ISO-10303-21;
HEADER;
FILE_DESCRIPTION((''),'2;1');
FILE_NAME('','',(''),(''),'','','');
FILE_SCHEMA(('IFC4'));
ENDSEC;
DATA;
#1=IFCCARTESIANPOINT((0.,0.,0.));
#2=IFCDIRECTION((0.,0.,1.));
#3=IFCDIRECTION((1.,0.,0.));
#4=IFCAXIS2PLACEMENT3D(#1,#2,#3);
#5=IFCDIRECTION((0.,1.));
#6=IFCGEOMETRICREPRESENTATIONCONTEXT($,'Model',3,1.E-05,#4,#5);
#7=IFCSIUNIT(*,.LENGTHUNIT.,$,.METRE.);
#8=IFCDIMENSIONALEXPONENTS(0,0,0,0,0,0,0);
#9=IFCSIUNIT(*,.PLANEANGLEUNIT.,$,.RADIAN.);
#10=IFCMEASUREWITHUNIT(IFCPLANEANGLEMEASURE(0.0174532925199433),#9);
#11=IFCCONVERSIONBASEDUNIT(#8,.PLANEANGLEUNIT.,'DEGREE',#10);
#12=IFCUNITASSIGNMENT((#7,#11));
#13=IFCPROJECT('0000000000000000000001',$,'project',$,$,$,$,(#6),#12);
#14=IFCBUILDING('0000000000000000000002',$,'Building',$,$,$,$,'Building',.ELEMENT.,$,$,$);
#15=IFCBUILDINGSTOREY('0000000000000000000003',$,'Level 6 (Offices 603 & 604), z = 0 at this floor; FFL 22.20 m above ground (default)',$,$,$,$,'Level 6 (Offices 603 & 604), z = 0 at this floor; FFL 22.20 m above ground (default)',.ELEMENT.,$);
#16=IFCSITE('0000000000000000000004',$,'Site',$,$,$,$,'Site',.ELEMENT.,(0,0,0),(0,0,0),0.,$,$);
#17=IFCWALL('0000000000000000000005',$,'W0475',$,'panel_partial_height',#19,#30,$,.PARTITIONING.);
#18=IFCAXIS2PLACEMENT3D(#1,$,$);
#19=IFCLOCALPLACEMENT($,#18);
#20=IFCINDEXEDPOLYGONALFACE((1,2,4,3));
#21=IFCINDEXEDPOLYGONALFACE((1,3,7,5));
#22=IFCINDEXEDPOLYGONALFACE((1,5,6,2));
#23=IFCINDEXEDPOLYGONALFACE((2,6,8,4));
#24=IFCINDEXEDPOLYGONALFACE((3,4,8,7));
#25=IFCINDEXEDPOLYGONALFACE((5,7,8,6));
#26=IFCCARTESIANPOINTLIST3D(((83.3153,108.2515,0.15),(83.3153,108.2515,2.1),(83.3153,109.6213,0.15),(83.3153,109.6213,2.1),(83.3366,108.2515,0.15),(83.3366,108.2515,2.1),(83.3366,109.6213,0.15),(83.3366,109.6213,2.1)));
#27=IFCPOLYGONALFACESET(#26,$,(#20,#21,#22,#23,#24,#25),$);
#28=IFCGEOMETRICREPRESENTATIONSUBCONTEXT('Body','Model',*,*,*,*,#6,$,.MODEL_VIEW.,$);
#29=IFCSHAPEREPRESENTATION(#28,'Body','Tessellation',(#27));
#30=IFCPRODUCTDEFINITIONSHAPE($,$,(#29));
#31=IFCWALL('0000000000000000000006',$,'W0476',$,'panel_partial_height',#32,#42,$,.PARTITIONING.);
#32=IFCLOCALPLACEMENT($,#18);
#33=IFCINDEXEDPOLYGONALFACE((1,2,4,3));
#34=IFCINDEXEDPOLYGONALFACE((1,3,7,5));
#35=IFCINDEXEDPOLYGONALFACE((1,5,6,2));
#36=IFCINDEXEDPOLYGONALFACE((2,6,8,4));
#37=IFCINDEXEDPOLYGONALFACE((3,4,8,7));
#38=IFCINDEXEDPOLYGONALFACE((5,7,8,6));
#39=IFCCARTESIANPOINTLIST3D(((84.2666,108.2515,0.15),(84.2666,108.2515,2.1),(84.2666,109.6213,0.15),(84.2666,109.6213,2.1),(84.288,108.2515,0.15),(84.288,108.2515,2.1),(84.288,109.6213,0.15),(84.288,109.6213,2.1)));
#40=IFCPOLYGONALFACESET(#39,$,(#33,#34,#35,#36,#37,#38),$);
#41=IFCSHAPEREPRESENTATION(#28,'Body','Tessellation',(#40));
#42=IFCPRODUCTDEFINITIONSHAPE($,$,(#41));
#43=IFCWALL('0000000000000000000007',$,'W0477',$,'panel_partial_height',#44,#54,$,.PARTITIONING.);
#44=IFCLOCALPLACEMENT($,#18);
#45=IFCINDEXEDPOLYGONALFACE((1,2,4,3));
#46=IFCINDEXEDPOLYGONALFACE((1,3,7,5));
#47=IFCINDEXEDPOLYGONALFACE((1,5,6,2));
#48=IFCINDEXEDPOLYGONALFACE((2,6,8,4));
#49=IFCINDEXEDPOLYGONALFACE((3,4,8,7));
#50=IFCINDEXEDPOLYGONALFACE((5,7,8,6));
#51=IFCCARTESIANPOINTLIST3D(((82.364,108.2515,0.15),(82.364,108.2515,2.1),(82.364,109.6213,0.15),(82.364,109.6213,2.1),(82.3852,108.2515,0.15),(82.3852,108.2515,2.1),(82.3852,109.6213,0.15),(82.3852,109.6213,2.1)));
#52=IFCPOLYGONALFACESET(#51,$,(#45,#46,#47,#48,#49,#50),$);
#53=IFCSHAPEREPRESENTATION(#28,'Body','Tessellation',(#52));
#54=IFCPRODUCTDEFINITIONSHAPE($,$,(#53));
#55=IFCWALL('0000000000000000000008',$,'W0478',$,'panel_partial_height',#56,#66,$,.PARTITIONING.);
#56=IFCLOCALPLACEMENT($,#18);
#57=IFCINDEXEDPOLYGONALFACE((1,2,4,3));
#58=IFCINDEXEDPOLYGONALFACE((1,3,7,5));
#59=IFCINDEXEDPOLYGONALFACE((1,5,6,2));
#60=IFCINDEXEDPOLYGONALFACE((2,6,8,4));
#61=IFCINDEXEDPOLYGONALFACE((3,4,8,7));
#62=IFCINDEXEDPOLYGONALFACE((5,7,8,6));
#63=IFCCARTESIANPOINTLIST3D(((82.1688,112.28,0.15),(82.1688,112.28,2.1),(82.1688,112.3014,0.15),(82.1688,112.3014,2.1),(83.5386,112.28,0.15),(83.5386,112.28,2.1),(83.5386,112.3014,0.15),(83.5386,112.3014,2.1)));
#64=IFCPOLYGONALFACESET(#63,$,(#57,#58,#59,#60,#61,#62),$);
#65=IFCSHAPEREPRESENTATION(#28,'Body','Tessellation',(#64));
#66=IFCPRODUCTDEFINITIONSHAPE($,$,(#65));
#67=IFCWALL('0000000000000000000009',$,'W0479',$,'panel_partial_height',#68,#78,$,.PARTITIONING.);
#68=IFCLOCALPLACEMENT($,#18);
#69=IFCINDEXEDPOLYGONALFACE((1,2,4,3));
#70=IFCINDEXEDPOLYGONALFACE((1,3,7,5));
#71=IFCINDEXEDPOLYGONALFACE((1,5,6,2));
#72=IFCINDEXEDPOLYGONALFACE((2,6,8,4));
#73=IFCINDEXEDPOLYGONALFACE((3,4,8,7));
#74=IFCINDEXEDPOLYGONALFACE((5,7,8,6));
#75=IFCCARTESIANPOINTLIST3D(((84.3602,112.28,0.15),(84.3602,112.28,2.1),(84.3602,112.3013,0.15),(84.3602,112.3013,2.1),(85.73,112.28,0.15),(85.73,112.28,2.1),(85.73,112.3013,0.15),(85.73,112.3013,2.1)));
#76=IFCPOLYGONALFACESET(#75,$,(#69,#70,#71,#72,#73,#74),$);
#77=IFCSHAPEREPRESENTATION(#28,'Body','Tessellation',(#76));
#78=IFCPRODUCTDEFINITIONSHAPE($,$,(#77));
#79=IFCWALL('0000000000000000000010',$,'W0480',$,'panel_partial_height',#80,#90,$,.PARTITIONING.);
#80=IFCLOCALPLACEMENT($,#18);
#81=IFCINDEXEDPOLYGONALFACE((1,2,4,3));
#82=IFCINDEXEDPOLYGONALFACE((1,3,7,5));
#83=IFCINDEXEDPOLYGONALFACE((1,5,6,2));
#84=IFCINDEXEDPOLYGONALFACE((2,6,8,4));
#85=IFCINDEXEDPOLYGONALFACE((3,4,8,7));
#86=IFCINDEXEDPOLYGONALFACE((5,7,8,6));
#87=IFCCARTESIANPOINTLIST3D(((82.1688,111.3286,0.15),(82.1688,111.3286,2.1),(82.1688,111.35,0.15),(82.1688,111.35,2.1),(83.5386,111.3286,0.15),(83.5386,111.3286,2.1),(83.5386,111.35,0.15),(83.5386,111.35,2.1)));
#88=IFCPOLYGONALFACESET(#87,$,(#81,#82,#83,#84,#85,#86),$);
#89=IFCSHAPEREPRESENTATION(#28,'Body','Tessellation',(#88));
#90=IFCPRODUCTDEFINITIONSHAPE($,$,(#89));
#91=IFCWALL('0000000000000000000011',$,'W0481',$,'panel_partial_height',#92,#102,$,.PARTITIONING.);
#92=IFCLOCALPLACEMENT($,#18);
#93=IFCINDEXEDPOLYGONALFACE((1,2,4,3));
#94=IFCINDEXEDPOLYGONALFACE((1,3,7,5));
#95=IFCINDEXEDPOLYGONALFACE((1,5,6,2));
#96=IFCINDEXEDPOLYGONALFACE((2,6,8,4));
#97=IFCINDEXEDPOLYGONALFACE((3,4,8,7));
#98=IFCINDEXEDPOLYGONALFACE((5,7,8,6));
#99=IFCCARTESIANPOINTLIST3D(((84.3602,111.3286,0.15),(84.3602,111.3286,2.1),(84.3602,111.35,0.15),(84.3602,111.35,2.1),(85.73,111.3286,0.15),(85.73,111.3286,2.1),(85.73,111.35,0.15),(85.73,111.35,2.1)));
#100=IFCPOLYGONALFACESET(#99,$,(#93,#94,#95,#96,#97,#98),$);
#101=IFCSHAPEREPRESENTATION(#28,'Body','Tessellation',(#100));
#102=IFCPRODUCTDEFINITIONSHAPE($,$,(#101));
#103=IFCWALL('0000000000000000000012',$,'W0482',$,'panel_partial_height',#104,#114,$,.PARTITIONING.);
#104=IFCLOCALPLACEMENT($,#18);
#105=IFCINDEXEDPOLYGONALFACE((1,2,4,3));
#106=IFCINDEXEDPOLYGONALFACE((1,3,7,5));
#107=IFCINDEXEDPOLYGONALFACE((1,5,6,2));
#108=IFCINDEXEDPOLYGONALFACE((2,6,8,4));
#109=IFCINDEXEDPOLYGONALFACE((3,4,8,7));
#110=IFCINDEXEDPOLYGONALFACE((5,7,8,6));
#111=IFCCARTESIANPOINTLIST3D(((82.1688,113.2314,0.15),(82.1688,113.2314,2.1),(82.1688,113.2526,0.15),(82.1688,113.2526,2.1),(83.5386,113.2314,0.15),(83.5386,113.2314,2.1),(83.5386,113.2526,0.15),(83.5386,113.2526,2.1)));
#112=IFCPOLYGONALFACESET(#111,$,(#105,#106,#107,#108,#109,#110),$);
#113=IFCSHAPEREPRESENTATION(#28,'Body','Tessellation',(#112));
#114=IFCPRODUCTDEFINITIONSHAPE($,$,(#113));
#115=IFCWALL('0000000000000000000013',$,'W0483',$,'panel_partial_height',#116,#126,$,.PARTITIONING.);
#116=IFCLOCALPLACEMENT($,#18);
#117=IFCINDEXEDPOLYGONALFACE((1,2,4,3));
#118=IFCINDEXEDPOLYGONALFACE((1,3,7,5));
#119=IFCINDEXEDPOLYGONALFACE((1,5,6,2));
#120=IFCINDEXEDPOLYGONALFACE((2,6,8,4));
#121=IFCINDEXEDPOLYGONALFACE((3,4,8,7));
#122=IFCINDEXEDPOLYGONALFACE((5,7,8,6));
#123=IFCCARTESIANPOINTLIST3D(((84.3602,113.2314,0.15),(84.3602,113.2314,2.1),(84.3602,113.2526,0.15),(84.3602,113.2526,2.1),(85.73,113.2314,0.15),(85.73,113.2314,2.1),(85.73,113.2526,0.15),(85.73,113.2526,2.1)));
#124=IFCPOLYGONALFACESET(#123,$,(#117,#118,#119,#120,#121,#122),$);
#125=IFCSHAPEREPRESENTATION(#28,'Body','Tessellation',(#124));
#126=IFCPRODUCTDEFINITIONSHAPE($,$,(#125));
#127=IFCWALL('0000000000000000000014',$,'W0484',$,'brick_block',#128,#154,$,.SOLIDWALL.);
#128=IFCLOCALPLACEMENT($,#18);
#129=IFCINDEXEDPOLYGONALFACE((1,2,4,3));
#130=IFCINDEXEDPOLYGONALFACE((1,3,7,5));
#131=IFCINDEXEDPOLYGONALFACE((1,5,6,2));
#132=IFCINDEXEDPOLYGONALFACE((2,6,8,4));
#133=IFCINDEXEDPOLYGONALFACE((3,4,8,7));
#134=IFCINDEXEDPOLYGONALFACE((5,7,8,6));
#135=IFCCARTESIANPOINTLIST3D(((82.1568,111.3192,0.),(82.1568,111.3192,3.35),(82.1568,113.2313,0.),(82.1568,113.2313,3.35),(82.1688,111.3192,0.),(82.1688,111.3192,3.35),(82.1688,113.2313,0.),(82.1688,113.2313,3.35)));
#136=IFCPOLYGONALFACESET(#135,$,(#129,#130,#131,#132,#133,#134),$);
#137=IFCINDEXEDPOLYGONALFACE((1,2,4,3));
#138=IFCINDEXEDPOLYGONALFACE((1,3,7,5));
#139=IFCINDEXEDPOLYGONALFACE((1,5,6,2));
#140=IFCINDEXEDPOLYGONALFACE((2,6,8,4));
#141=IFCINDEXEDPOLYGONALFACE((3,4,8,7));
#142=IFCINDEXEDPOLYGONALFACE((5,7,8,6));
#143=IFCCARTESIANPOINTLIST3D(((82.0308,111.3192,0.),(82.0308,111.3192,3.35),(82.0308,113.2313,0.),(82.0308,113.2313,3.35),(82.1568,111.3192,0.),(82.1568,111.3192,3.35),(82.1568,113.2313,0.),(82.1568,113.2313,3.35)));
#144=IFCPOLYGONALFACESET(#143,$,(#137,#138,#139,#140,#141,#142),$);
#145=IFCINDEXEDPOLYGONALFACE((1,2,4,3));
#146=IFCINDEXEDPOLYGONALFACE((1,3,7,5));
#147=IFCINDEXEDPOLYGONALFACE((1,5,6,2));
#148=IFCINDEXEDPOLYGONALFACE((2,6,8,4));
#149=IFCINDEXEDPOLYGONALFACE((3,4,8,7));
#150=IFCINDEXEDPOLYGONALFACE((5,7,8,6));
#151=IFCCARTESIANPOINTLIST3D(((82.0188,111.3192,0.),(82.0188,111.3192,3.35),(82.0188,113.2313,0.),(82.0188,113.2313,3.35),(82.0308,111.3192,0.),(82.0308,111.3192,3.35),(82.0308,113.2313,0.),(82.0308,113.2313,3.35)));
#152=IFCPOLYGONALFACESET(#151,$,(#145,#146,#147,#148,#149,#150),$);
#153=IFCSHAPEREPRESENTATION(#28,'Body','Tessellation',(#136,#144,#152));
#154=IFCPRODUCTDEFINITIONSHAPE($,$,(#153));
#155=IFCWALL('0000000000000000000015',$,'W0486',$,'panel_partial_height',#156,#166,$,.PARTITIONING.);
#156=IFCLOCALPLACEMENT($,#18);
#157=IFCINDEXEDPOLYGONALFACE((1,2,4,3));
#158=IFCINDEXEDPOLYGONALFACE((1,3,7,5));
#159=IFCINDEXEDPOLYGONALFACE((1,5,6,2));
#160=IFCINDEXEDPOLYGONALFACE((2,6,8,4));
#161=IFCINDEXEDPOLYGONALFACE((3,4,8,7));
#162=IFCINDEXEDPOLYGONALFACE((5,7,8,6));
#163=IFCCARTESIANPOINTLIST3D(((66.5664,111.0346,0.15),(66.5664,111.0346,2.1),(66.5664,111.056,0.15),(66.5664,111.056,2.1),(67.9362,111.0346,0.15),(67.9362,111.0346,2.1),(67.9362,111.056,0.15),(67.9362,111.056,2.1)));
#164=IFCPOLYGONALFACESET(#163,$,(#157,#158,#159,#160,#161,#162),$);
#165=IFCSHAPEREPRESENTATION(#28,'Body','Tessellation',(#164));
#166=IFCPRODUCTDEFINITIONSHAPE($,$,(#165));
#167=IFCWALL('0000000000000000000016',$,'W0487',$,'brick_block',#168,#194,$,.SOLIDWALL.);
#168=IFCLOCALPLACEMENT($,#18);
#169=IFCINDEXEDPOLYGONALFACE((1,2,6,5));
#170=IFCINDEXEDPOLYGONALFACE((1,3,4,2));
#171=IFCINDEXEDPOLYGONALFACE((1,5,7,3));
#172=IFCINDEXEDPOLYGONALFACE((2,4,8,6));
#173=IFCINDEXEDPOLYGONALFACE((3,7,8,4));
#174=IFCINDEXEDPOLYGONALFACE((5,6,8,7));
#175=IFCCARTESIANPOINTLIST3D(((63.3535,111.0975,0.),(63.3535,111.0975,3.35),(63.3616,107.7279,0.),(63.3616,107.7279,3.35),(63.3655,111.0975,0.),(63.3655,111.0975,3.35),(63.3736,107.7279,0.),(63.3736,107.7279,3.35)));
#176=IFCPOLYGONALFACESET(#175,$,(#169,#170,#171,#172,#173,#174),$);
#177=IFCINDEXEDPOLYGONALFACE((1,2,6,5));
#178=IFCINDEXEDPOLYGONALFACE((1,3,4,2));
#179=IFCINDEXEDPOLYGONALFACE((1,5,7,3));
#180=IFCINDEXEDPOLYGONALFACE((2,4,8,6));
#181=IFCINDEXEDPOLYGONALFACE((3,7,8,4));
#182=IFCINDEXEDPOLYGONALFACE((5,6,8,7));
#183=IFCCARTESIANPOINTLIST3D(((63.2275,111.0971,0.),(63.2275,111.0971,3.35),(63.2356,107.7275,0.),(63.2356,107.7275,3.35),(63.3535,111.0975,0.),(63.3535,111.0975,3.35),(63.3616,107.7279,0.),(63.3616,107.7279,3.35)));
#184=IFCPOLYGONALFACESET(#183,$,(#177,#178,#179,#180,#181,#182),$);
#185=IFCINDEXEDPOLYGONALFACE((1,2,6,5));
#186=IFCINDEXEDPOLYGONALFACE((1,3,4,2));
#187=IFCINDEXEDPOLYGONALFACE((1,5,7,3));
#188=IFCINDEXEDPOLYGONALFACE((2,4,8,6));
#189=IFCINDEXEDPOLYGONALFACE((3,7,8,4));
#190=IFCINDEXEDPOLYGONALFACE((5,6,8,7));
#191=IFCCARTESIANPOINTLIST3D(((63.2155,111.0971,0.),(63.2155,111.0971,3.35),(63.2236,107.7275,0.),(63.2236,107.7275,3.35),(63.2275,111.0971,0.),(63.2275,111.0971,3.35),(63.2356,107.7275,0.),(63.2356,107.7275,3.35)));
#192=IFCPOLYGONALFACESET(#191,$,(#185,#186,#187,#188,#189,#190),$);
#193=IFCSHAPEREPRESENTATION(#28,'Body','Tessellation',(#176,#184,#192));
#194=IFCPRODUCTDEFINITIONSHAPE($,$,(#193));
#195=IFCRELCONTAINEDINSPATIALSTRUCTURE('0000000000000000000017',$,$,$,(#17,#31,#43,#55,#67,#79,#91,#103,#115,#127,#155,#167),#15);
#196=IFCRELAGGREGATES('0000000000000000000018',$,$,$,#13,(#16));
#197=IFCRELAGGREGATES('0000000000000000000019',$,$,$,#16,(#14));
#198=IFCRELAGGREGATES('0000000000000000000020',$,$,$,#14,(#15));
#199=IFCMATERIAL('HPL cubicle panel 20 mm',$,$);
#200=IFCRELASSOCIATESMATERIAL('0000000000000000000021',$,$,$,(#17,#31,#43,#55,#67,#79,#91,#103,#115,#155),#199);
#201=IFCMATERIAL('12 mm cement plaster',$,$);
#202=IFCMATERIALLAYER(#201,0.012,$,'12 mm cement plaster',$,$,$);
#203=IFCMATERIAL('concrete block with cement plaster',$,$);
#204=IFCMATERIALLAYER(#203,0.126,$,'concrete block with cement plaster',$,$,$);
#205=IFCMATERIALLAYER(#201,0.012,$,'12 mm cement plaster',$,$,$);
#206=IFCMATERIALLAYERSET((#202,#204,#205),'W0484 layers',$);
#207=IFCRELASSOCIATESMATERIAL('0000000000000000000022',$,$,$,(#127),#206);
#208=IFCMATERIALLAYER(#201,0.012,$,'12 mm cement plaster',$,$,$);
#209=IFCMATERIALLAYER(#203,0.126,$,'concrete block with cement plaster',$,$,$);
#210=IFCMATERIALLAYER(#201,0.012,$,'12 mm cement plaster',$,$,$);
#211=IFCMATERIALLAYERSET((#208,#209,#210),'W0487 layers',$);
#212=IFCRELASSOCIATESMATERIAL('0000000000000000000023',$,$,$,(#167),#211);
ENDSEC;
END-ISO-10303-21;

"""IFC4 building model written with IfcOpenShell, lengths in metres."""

from ifc_helpers import new_model, entity, si_unit, converted_unit, direction, frame, frame_2d, origin_with_axes, origin_2d_with_axis, place, context, subcontext, project, spatial, rectangle, extrude, material, layer, layer_set, layer_usage, element, save


model = new_model("IFC4")

# Units and contexts
model_context = context("Model", 3, precision=1e-05, world=origin_with_axes(), true_north=direction((0.0, 1.0)))
body_context = subcontext(model_context, "Body", "Model", "MODEL_VIEW")
ifc_project = project(units=[si_unit("LENGTHUNIT", "METRE"), converted_unit("PLANEANGLEUNIT", "DEGREE", entity("IfcPlaneAngleMeasure", 0.0174532925199433), si_unit("PLANEANGLEUNIT", "RADIAN"), dimensions=[0, 0, 0, 0, 0, 0, 0])], contexts=[model_context])

# Site, building, storey
site = spatial("IfcSite", under=ifc_project, Name="Site", LongName="Site", CompositionType="ELEMENT", RefLatitude=(0, 0, 0), RefLongitude=(0, 0, 0), RefElevation=0.0)
building = spatial("IfcBuilding", under=site, Name="Building", LongName="Building", CompositionType="ELEMENT")
storey = spatial("IfcBuildingStorey", under=building, Name="Level 6 (Offices 603 & 604), z = 0 at this floor; FFL 22.20 m above ground (default)", LongName="Level 6 (Offices 603 & 604), z = 0 at this floor; FFL 22.20 m above ground (default)", CompositionType="ELEMENT")

# Walls
ifc_material_1 = material(Name="HPL cubicle panel 20 mm")
placement = place(None, origin_with_axes())
element("IfcWall", 1, at=placement, inside=storey, material=ifc_material_1, Name="W0475", ObjectType="panel_partial_height", PredefinedType="PARTITIONING", context=body_context, shape_type="SweptSolid", body=[
    extrude(rectangle(XDim=1.3698, YDim=0.0213, at=frame_2d((0.0, 0.0), x_axis=(0.0, 1.0))), frame((83.3259, 108.9364, 0.15), z_axis=(0.0, 0.0, 1.0), x_axis=(1.0, 0.0, 0.0)), (0.0, 0.0, 1.0), 1.95),
])
element("IfcWall", 2, at=placement, inside=storey, material=ifc_material_1, Name="W0476", ObjectType="panel_partial_height", PredefinedType="PARTITIONING", context=body_context, shape_type="SweptSolid", body=[
    extrude(rectangle(XDim=1.3698, YDim=0.0213, at=frame_2d((0.0, 0.0), x_axis=(0.0, 1.0))), frame((84.2773, 108.9364, 0.15), z_axis=(0.0, 0.0, 1.0), x_axis=(1.0, 0.0, 0.0)), (0.0, 0.0, 1.0), 1.95),
])
element("IfcWall", 3, at=placement, inside=storey, material=ifc_material_1, Name="W0477", ObjectType="panel_partial_height", PredefinedType="PARTITIONING", context=body_context, shape_type="SweptSolid", body=[
    extrude(rectangle(XDim=1.3698, YDim=0.0213, at=frame_2d((0.0, 0.0), x_axis=(0.0, 1.0))), frame((82.3746, 108.9364, 0.15), z_axis=(0.0, 0.0, 1.0), x_axis=(1.0, 0.0, 0.0)), (0.0, 0.0, 1.0), 1.95),
])
element("IfcWall", 4, at=placement, inside=storey, material=ifc_material_1, Name="W0478", ObjectType="panel_partial_height", PredefinedType="PARTITIONING", context=body_context, shape_type="SweptSolid", body=[
    extrude(rectangle(XDim=1.3698, YDim=0.0213, at=origin_2d_with_axis()), frame((82.8537, 112.2907, 0.15), z_axis=(0.0, 0.0, 1.0), x_axis=(1.0, 0.0, 0.0)), (0.0, 0.0, 1.0), 1.95),
])
element("IfcWall", 5, at=placement, inside=storey, material=ifc_material_1, Name="W0479", ObjectType="panel_partial_height", PredefinedType="PARTITIONING", context=body_context, shape_type="SweptSolid", body=[
    extrude(rectangle(XDim=1.3698, YDim=0.0213, at=frame_2d((0.0, 0.0), x_axis=(1.0, 0.0))), frame((85.0451, 112.2907, 0.15), z_axis=(0.0, 0.0, 1.0), x_axis=(1.0, 0.0, 0.0)), (0.0, 0.0, 1.0), 1.95),
])
element("IfcWall", 6, at=placement, inside=storey, material=ifc_material_1, Name="W0480", ObjectType="panel_partial_height", PredefinedType="PARTITIONING", context=body_context, shape_type="SweptSolid", body=[
    extrude(rectangle(XDim=1.3698, YDim=0.0213, at=origin_2d_with_axis()), frame((82.8537, 111.3393, 0.15), z_axis=(0.0, 0.0, 1.0), x_axis=(1.0, 0.0, 0.0)), (0.0, 0.0, 1.0), 1.95),
])
element("IfcWall", 7, at=placement, inside=storey, material=ifc_material_1, Name="W0481", ObjectType="panel_partial_height", PredefinedType="PARTITIONING", context=body_context, shape_type="SweptSolid", body=[
    extrude(rectangle(XDim=1.3698, YDim=0.0213, at=frame_2d((0.0, 0.0), x_axis=(1.0, 0.0))), frame((85.0451, 111.3393, 0.15), z_axis=(0.0, 0.0, 1.0), x_axis=(1.0, 0.0, 0.0)), (0.0, 0.0, 1.0), 1.95),
])
element("IfcWall", 8, at=placement, inside=storey, material=ifc_material_1, Name="W0482", ObjectType="panel_partial_height", PredefinedType="PARTITIONING", context=body_context, shape_type="SweptSolid", body=[
    extrude(rectangle(XDim=1.3698, YDim=0.0213, at=origin_2d_with_axis()), frame((82.8537, 113.242, 0.15), z_axis=(0.0, 0.0, 1.0), x_axis=(1.0, 0.0, 0.0)), (0.0, 0.0, 1.0), 1.95),
])
element("IfcWall", 9, at=placement, inside=storey, material=ifc_material_1, Name="W0483", ObjectType="panel_partial_height", PredefinedType="PARTITIONING", context=body_context, shape_type="SweptSolid", body=[
    extrude(rectangle(XDim=1.3698, YDim=0.0213, at=frame_2d((0.0, 0.0), x_axis=(1.0, 0.0))), frame((85.0451, 113.242, 0.15), z_axis=(0.0, 0.0, 1.0), x_axis=(1.0, 0.0, 0.0)), (0.0, 0.0, 1.0), 1.95),
])
ifc_material_2 = material(Name="12 mm cement plaster")
ifc_layer_1 = layer(ifc_material_2, 0.012, Name="12 mm cement plaster")
ifc_material_3 = material(Name="concrete block with cement plaster")
ifc_layer_2 = layer(ifc_material_3, 0.126, Name="concrete block with cement plaster")
ifc_layer_3 = layer(ifc_material_2, 0.012, Name="12 mm cement plaster")
ifc_layer_set_1 = layer_set([ifc_layer_1, ifc_layer_2, ifc_layer_3], Name="W0484 layers")
ifc_layer_usage_1 = layer_usage(ifc_layer_set_1, "AXIS2", "POSITIVE", -0.075)
element("IfcWall", 10, at=placement, inside=storey, material=ifc_layer_usage_1, Name="W0484", ObjectType="brick_block", PredefinedType="SOLIDWALL", context=body_context, shape_type="SweptSolid", body=[
    extrude(rectangle(XDim=1.9121, YDim=0.012, at=frame_2d((0.0, 0.0), x_axis=(0.0, 1.0))), frame((82.1628, 112.2752, 0.0), z_axis=(0.0, 0.0, 1.0), x_axis=(1.0, 0.0, 0.0)), (0.0, 0.0, 1.0), 3.35),
    extrude(rectangle(XDim=1.9121, YDim=0.126, at=frame_2d((-0.069, 0.0), x_axis=(0.0, 1.0))), frame((82.1628, 112.2752, 0.0), z_axis=(0.0, 0.0, 1.0), x_axis=(1.0, 0.0, 0.0)), (0.0, 0.0, 1.0), 3.35),
    extrude(rectangle(XDim=1.9121, YDim=0.012, at=frame_2d((-0.138, 0.0), x_axis=(0.0, 1.0))), frame((82.1628, 112.2752, 0.0), z_axis=(0.0, 0.0, 1.0), x_axis=(1.0, 0.0, 0.0)), (0.0, 0.0, 1.0), 3.35),
])
element("IfcWall", 11, at=placement, inside=storey, material=ifc_material_1, Name="W0486", ObjectType="panel_partial_height", PredefinedType="PARTITIONING", context=body_context, shape_type="SweptSolid", body=[
    extrude(rectangle(XDim=1.3698, YDim=0.0213, at=frame_2d((0.0, 0.0), x_axis=(1.0, 0.0))), frame((67.2513, 111.0453, 0.15), z_axis=(0.0, 0.0, 1.0), x_axis=(1.0, 0.0, 0.0)), (0.0, 0.0, 1.0), 1.95),
])
ifc_layer_4 = layer(ifc_material_2, 0.012, Name="12 mm cement plaster")
ifc_layer_5 = layer(ifc_material_3, 0.126, Name="concrete block with cement plaster")
ifc_layer_6 = layer(ifc_material_2, 0.012, Name="12 mm cement plaster")
ifc_layer_set_2 = layer_set([ifc_layer_4, ifc_layer_5, ifc_layer_6], Name="W0487 layers")
ifc_layer_usage_2 = layer_usage(ifc_layer_set_2, "AXIS2", "POSITIVE", -0.075)
element("IfcWall", 12, at=placement, inside=storey, material=ifc_layer_usage_2, Name="W0487", ObjectType="brick_block", PredefinedType="SOLIDWALL", context=body_context, shape_type="SweptSolid", body=[
    extrude(rectangle(XDim=3.3696, YDim=0.012, at=frame_2d((0.0, 0.0), x_axis=(0.002404, -0.999997))), frame((63.3635, 109.4127, 0.0), z_axis=(0.0, 0.0, 1.0), x_axis=(1.0, 0.0, 0.0)), (0.0, 0.0, 1.0), 3.35),
    extrude(rectangle(XDim=3.3696, YDim=0.126, at=frame_2d((-0.069, -0.0002), x_axis=(0.002404, -0.999997))), frame((63.3635, 109.4127, 0.0), z_axis=(0.0, 0.0, 1.0), x_axis=(1.0, 0.0, 0.0)), (0.0, 0.0, 1.0), 3.35),
    extrude(rectangle(XDim=3.3696, YDim=0.012, at=frame_2d((-0.138, -0.0003), x_axis=(0.002404, -0.999997))), frame((63.3635, 109.4127, 0.0), z_axis=(0.0, 0.0, 1.0), x_axis=(1.0, 0.0, 0.0)), (0.0, 0.0, 1.0), 3.35),
])

save(model, "model.ifc")
